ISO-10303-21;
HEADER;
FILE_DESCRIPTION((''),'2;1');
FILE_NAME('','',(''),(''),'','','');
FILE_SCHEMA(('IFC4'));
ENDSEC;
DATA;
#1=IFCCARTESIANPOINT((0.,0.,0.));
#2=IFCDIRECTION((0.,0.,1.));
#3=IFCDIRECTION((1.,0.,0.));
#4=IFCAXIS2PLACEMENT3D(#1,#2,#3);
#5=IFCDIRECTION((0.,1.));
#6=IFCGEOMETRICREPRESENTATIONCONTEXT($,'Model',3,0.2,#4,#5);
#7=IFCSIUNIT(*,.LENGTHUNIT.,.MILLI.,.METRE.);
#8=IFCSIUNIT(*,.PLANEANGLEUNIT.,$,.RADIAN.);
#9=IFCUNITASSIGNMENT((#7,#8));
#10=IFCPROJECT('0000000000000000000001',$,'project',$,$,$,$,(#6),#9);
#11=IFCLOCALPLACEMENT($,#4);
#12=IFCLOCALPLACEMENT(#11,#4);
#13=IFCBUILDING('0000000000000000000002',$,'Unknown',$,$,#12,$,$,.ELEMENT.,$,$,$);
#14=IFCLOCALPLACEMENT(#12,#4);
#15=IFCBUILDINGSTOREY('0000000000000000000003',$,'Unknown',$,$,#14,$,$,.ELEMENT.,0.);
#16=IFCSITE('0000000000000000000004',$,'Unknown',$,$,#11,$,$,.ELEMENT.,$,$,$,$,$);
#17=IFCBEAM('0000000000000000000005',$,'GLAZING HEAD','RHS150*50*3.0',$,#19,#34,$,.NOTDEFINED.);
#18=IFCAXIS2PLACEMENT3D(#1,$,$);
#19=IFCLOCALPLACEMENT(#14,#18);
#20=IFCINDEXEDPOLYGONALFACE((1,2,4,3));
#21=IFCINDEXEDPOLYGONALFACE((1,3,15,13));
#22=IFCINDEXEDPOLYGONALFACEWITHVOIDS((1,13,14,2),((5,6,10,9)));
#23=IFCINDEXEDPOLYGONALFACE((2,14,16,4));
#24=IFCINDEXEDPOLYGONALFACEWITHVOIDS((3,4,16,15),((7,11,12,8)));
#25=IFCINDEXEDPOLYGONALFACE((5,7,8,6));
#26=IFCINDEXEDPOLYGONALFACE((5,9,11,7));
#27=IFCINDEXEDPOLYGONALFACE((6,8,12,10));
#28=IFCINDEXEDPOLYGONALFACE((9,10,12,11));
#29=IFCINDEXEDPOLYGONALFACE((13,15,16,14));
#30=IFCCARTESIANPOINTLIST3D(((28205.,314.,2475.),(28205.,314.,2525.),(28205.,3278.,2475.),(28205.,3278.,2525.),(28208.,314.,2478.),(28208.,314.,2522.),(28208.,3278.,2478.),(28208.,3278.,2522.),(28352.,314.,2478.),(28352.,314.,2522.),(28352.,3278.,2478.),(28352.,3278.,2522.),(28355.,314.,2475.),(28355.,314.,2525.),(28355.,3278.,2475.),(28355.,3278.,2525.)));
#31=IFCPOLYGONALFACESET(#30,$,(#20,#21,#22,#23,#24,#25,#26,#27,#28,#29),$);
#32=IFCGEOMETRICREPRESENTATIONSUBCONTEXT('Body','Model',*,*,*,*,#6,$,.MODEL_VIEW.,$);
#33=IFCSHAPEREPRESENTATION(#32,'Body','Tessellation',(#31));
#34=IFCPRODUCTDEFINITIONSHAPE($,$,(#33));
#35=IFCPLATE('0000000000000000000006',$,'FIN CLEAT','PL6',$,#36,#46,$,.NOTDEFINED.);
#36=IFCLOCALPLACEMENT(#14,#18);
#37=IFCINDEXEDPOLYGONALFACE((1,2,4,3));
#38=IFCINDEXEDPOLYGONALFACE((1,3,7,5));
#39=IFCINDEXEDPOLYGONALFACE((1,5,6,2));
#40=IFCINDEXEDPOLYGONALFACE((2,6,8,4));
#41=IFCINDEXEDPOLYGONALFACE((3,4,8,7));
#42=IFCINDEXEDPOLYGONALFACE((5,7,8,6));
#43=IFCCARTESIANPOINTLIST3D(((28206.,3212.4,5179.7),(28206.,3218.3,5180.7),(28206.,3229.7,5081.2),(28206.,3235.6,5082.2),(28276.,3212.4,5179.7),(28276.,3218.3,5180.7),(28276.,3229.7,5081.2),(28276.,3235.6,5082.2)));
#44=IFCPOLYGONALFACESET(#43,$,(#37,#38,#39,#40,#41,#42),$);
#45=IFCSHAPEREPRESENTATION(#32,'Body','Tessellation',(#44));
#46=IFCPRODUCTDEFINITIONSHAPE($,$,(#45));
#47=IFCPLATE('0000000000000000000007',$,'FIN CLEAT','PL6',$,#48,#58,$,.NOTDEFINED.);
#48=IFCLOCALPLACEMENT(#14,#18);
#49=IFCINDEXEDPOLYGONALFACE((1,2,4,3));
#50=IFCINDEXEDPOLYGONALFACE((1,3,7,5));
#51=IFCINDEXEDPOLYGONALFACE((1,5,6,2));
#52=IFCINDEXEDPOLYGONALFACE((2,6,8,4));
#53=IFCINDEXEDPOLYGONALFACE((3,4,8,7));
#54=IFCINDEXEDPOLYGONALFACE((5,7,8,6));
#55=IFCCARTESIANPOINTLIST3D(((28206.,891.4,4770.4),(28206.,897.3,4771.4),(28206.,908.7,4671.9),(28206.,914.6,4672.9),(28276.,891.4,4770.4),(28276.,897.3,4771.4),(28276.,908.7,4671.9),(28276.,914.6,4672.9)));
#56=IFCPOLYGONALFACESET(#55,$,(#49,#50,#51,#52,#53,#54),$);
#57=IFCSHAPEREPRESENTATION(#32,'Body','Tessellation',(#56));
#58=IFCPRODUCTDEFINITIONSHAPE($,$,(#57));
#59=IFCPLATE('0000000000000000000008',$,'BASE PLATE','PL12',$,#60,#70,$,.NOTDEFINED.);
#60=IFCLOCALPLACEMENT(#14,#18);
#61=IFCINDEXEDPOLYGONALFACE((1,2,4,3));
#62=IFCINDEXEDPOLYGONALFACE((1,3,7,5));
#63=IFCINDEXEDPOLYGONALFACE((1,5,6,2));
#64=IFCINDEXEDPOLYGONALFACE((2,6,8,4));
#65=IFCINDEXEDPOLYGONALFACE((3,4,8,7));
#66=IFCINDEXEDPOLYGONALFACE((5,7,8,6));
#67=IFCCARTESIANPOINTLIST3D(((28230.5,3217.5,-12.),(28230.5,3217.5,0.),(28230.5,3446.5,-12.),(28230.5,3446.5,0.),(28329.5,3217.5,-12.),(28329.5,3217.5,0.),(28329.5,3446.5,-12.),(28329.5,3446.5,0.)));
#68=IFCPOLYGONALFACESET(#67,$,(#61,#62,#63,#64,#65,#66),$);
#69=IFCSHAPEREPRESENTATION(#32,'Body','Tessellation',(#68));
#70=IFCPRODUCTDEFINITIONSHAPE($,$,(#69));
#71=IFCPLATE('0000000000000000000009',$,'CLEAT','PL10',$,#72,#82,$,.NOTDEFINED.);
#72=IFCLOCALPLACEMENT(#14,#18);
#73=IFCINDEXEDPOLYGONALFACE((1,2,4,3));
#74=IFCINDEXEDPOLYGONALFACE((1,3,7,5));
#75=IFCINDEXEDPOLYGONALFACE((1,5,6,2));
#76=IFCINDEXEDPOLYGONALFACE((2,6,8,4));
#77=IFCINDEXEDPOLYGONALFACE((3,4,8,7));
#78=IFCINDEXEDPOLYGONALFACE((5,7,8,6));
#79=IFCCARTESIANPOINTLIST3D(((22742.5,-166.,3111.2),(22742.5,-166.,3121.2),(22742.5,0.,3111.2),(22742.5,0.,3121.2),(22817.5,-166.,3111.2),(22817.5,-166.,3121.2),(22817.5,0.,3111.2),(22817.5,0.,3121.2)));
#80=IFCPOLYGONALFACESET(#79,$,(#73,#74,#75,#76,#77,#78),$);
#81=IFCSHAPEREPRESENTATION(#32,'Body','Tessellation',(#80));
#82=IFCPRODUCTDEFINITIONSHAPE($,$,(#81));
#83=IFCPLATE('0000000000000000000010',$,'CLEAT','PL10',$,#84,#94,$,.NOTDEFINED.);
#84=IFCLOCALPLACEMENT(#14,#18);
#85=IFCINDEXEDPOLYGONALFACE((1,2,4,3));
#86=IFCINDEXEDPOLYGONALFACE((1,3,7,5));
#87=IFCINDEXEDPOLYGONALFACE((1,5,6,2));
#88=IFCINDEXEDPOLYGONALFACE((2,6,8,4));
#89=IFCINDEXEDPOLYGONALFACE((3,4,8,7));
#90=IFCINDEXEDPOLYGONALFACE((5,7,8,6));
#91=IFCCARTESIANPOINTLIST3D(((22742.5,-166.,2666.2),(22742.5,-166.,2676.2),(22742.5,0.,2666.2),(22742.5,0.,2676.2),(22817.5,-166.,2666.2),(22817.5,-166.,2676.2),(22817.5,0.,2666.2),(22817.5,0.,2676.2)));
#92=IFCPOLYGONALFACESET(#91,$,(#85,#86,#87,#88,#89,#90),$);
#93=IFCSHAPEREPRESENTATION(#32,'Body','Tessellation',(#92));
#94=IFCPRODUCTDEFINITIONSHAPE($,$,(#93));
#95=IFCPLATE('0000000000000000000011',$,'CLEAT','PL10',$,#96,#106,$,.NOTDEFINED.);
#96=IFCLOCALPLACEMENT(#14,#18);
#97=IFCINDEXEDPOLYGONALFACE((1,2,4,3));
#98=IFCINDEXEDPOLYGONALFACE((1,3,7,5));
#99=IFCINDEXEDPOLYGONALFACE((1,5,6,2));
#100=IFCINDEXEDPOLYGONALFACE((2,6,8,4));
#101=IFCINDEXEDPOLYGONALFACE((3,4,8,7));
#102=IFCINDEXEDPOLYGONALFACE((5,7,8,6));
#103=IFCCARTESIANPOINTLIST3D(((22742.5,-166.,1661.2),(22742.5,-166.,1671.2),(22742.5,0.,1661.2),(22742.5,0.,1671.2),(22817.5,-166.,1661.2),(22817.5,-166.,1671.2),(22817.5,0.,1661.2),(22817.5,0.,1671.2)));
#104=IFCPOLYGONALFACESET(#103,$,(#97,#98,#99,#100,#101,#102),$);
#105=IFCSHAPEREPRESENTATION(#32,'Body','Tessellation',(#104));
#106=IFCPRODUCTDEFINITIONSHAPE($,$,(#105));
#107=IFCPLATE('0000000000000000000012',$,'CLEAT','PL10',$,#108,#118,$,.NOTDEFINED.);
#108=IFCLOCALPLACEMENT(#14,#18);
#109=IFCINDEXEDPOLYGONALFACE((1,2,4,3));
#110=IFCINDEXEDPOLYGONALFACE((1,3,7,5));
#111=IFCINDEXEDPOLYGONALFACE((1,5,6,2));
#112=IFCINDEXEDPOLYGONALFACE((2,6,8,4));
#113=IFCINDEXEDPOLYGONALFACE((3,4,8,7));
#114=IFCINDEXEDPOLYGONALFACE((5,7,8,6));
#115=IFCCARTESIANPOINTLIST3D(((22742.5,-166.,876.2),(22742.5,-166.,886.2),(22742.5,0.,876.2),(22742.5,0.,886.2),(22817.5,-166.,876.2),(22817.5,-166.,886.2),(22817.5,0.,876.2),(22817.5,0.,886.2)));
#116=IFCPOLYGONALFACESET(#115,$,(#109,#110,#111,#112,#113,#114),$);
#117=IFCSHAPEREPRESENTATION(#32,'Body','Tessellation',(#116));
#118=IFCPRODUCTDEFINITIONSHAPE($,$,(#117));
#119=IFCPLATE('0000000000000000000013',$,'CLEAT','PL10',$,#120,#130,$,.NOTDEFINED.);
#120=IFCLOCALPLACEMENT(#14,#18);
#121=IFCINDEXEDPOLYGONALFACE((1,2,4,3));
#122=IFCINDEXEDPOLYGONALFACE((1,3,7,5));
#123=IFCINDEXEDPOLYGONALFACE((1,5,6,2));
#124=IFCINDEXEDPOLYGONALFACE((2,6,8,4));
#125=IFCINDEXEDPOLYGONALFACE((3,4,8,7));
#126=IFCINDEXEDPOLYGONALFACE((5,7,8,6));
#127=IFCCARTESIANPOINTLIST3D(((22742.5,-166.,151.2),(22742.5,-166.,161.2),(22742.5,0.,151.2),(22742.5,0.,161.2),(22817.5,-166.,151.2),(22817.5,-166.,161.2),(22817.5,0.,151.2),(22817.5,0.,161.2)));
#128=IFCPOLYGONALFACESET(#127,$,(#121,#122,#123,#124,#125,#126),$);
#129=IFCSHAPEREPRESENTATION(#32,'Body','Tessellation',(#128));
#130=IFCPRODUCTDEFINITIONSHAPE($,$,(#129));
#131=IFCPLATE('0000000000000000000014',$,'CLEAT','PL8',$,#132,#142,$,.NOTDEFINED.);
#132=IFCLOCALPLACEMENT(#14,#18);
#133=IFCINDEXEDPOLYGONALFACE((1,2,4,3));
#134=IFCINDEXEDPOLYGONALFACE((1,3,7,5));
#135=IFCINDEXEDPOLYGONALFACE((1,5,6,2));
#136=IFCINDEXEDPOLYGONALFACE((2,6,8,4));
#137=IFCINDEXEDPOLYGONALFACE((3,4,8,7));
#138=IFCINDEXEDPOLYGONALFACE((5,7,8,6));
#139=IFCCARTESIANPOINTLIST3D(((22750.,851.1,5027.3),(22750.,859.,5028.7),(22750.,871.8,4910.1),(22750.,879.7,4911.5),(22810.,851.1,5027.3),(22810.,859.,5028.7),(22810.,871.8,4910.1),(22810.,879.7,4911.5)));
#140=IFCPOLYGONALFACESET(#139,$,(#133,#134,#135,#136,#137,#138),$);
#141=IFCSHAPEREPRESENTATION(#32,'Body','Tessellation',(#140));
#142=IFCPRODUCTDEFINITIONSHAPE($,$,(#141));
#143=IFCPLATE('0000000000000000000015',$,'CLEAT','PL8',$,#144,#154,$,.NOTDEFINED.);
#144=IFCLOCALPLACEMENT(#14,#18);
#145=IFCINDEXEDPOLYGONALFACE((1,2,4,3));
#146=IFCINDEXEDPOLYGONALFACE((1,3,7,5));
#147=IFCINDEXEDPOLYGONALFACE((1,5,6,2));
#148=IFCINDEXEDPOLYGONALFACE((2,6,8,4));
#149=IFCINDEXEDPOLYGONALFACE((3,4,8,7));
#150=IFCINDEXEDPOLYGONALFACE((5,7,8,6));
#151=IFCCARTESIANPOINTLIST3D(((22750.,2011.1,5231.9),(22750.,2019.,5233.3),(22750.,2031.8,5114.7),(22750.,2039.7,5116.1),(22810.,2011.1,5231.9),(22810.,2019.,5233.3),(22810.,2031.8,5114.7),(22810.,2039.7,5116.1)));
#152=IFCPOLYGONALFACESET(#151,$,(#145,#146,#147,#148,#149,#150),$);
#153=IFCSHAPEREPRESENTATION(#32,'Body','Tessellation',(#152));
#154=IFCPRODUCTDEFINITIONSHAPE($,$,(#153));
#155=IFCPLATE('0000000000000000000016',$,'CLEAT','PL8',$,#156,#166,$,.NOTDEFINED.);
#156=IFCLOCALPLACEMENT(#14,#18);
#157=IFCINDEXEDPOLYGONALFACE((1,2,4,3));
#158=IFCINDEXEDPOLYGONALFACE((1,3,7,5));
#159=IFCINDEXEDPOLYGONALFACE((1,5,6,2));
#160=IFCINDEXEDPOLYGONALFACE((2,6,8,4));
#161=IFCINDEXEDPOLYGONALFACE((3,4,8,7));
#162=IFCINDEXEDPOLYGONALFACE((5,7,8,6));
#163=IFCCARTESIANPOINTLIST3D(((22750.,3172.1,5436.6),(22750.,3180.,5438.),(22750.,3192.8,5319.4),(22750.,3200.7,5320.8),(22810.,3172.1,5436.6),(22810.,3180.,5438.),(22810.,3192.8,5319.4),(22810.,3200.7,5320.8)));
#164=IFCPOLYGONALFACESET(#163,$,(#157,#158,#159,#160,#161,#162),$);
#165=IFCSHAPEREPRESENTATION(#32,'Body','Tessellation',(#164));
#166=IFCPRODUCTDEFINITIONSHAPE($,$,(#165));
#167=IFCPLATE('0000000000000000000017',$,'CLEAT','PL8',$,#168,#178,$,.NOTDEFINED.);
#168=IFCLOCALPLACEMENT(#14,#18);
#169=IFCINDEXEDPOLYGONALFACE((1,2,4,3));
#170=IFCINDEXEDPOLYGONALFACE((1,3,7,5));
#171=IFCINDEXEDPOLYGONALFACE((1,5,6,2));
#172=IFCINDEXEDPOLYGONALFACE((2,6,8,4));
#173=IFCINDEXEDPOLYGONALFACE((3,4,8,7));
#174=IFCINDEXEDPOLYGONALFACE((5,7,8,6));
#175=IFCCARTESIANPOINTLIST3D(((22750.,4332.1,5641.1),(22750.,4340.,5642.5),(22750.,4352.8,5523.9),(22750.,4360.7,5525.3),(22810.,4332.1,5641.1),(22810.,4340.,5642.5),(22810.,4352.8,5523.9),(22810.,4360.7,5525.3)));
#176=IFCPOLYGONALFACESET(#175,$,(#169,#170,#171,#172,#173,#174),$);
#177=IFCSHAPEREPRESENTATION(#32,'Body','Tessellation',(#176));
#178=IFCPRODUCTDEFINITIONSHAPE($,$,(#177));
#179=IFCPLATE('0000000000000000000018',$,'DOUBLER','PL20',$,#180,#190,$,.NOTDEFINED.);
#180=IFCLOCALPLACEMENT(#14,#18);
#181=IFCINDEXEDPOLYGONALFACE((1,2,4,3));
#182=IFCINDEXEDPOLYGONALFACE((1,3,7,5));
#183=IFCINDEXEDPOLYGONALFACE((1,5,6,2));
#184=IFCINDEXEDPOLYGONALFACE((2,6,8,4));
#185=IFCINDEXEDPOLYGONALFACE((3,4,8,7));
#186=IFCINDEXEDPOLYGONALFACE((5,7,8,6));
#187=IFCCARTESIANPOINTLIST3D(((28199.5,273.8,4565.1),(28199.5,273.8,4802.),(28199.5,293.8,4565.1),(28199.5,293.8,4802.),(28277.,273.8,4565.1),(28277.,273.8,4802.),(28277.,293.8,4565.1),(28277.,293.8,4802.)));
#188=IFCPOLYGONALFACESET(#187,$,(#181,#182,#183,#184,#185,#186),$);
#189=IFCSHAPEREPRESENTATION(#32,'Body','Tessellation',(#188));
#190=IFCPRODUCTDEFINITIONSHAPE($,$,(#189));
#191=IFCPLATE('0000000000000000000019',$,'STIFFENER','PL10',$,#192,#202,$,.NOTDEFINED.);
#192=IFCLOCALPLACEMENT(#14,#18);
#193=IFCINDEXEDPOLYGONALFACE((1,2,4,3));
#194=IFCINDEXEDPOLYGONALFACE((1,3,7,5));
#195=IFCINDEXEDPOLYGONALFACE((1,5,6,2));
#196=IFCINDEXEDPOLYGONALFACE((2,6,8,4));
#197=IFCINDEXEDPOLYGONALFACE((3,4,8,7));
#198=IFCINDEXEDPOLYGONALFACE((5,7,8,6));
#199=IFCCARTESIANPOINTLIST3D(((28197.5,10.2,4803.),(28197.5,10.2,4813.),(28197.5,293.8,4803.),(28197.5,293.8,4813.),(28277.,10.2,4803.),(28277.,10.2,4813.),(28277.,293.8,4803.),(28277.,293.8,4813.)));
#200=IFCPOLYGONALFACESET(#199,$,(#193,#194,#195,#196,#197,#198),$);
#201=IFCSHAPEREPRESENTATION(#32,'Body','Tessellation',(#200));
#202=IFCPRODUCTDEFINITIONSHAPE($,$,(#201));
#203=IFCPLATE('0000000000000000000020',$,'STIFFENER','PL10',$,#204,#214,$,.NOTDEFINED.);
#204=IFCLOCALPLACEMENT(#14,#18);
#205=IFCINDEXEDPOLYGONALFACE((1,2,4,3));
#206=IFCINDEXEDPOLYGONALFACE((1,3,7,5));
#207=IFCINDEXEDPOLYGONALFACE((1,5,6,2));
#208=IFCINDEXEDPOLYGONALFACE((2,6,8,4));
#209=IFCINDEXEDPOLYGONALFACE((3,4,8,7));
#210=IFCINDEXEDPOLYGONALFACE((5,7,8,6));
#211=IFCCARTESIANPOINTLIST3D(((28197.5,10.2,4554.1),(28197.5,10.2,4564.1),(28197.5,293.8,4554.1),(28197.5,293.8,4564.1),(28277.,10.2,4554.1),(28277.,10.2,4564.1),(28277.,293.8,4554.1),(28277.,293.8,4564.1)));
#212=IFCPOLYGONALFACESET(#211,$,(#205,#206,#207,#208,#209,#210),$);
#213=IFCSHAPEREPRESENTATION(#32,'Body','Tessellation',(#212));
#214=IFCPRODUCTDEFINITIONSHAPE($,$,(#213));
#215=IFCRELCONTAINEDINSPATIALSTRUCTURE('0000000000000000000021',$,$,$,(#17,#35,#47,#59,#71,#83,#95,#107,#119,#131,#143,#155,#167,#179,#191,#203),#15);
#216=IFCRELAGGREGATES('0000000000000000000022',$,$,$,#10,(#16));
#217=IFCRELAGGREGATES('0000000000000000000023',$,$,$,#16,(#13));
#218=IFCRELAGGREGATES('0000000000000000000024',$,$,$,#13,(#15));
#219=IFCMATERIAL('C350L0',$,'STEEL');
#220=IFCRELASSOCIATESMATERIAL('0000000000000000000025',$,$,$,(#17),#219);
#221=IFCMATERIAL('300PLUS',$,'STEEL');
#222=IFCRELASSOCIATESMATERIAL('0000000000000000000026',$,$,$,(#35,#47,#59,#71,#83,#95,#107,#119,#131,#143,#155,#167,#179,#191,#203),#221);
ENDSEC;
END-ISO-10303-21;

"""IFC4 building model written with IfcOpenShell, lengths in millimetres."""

from ifc_helpers import new_model, si_unit, direction, frame, origin_with_axes, place, context, subcontext, project, spatial, line, indexed_curve, outline, extrude, material, element, save


model = new_model("IFC4")

# Units and contexts
model_context = context("Model", 3, precision=0.2, world=origin_with_axes(), true_north=direction((0.0, 1.0)))
body_context = subcontext(model_context, "Body", "Model", "MODEL_VIEW")
ifc_project = project(units=[si_unit("LENGTHUNIT", "METRE", prefix="MILLI"), si_unit("PLANEANGLEUNIT", "RADIAN")], contexts=[model_context])

# Site, building, storey
site_placement = place(None, origin_with_axes())
site = spatial("IfcSite", under=ifc_project, at=site_placement, Name="Unknown", CompositionType="ELEMENT")
building_placement = place(site_placement, origin_with_axes())
building = spatial("IfcBuilding", under=site, at=building_placement, Name="Unknown", CompositionType="ELEMENT")
storey_placement = place(building_placement, origin_with_axes())
storey = spatial("IfcBuildingStorey", under=building, at=storey_placement, Name="Unknown", CompositionType="ELEMENT", Elevation=0.0)

# Shared definitions
ifc_material_1 = material(Name="300PLUS", Category="STEEL")

# Beam
ifc_material_2 = material(Name="C350L0", Category="STEEL")
beam_1_placement = place(storey_placement, frame((28280.0, 314.0, 2500.0), z_axis=(0.0, 0.0, 1.0), x_axis=(0.0, 1.0, 0.0)))
element("IfcBeam", 1, at=beam_1_placement, inside=storey, material=ifc_material_2, Name="GLAZING HEAD", Description="RHS150*50*3.0", PredefinedType="NOTDEFINED", context=body_context, shape_type="SolidModel", body=[
    extrude(outline(indexed_curve([(-25.0, -75.0), (25.0, -75.0), (25.0, 75.0), (-25.0, 75.0)], segments=[line(1, 2, 3, 4, 1)]), holes=[indexed_curve([(-22.0, -72.0), (-22.0, 72.0), (22.0, 72.0), (22.0, -72.0)], segments=[line(1, 2, 3, 4, 1)])]), frame((0.0, 0.0, 0.0), z_axis=(-1.0, 0.0, 0.0), x_axis=(0.0, 0.0, 1.0)), (0.0, 0.0, -1.0), 2964.0),
])

# Plates
for number, where, z_axis, x_axis, name in (
    (2, (28206.0, 3215.4, 5180.2), (0.0, 0.984924, 0.172987), (1.0, 0.0, 0.0), "FIN CLEAT"),
    (3, (28206.0, 894.4, 4770.9), (0.0, 0.984924, 0.172987), (1.0, 0.0, 0.0), "FIN CLEAT"),
):
    element("IfcPlate", number, at=place(storey_placement, frame(where, z_axis=z_axis, x_axis=x_axis)), inside=storey, material=ifc_material_1, Name=name, Description="PL6", PredefinedType="NOTDEFINED", context=body_context, shape_type="SolidModel", body=[
        extrude(outline(indexed_curve([(0.0, 0.0), (70.0, 0.0), (70.0, 100.0), (0.0, 100.0)], segments=[line(1, 2, 3, 4, 1)])), frame((0.0, 0.0, 3.0), z_axis=(0.0, 0.0, 1.0), x_axis=(1.0, 0.0, 0.0)), (0.0, 0.0, -1.0), 6.0),
    ])
plate_1_placement = place(storey_placement, frame((28230.5, 3217.5, -6.0), z_axis=(0.0, 0.0, 1.0), x_axis=(1.0, 0.0, 0.0)))
element("IfcPlate", 4, at=plate_1_placement, inside=storey, material=ifc_material_1, Name="BASE PLATE", Description="PL12", PredefinedType="NOTDEFINED", context=body_context, shape_type="SolidModel", body=[
    extrude(outline(indexed_curve([(0.0, 0.0), (99.0, 0.0), (99.0, 229.0), (0.0, 229.0)], segments=[line(1, 2, 3, 4, 1)])), frame((0.0, 0.0, 6.0), z_axis=(0.0, 0.0, 1.0), x_axis=(1.0, 0.0, 0.0)), (0.0, 0.0, -1.0), 12.0),
])
for number, where, z_axis, x_axis, name in (
    (5, (22817.5, 0.0, 3116.2), (0.0, 0.0, 1.0), (-1.0, 0.0, 0.0), "CLEAT"),
    (6, (22817.5, 0.0, 2671.2), (0.0, 0.0, 1.0), (-1.0, 0.0, 0.0), "CLEAT"),
    (7, (22817.5, 0.0, 1666.2), (0.0, 0.0, 1.0), (-1.0, 0.0, 0.0), "CLEAT"),
    (8, (22817.5, 0.0, 881.2), (0.0, 0.0, 1.0), (-1.0, 0.0, 0.0), "CLEAT"),
    (9, (22817.5, 0.0, 156.2), (0.0, 0.0, 1.0), (-1.0, 0.0, 0.0), "CLEAT"),
):
    element("IfcPlate", number, at=place(storey_placement, frame(where, z_axis=z_axis, x_axis=x_axis)), inside=storey, material=ifc_material_1, Name=name, Description="PL10", PredefinedType="NOTDEFINED", context=body_context, shape_type="SolidModel", body=[
        extrude(outline(indexed_curve([(0.0, 0.0), (75.0, 0.0), (75.0, 166.0), (0.0, 166.0)], segments=[line(1, 2, 3, 4, 1)])), frame((0.0, 0.0, 5.0), z_axis=(0.0, 0.0, 1.0), x_axis=(1.0, 0.0, 0.0)), (0.0, 0.0, -1.0), 10.0),
    ])
for number, where, z_axis, x_axis, name in (
    (10, (22810.0, 875.7, 4910.8), (0.0, 0.984758, 0.173929), (-1.0, 0.0, 0.0), "CLEAT"),
    (11, (22810.0, 2035.7, 5115.4), (0.0, 0.984758, 0.173929), (-1.0, 0.0, 0.0), "CLEAT"),
    (12, (22810.0, 3196.7, 5320.1), (0.0, 0.984758, 0.173929), (-1.0, 0.0, 0.0), "CLEAT"),
    (13, (22810.0, 4356.7, 5524.6), (0.0, 0.984758, 0.173929), (-1.0, 0.0, 0.0), "CLEAT"),
):
    element("IfcPlate", number, at=place(storey_placement, frame(where, z_axis=z_axis, x_axis=x_axis)), inside=storey, material=ifc_material_1, Name=name, Description="PL8", PredefinedType="NOTDEFINED", context=body_context, shape_type="SolidModel", body=[
        extrude(outline(indexed_curve([(0.0, 0.0), (60.0, 0.0), (60.0, 119.0), (0.0, 119.0)], segments=[line(1, 2, 3, 4, 1)])), frame((0.0, 0.0, 4.0), z_axis=(0.0, 0.0, 1.0), x_axis=(1.0, 0.0, 0.0)), (0.0, 0.0, -1.0), 8.0),
    ])
plate_2_placement = place(storey_placement, frame((28199.5, 283.8, 4565.1), z_axis=(0.0, -1.0, 0.0), x_axis=(1.0, 0.0, 0.0)))
element("IfcPlate", 14, at=plate_2_placement, inside=storey, material=ifc_material_1, Name="DOUBLER", Description="PL20", PredefinedType="NOTDEFINED", context=body_context, shape_type="SolidModel", body=[
    extrude(outline(indexed_curve([(0.0, 0.0), (77.5, 0.0), (77.5, 236.9), (0.0, 236.9)], segments=[line(1, 2, 3, 4, 1)])), frame((0.0, 0.0, 10.0), z_axis=(0.0, 0.0, 1.0), x_axis=(1.0, 0.0, 0.0)), (0.0, 0.0, -1.0), 20.0),
])
for number, where, z_axis, x_axis, name in (
    (15, (28197.5, 10.2, 4808.0), (0.0, 0.0, 1.0), (1.0, 0.0, 0.0), "STIFFENER"),
    (16, (28197.5, 10.2, 4559.1), (0.0, 0.0, 1.0), (1.0, 0.0, 0.0), "STIFFENER"),
):
    element("IfcPlate", number, at=place(storey_placement, frame(where, z_axis=z_axis, x_axis=x_axis)), inside=storey, material=ifc_material_1, Name=name, Description="PL10", PredefinedType="NOTDEFINED", context=body_context, shape_type="SolidModel", body=[
        extrude(outline(indexed_curve([(0.0, 0.0), (79.5, 0.0), (79.5, 283.6), (0.0, 283.6)], segments=[line(1, 2, 3, 4, 1)])), frame((0.0, 0.0, 5.0), z_axis=(0.0, 0.0, 1.0), x_axis=(1.0, 0.0, 0.0)), (0.0, 0.0, -1.0), 10.0),
    ])

save(model, "model.ifc")
